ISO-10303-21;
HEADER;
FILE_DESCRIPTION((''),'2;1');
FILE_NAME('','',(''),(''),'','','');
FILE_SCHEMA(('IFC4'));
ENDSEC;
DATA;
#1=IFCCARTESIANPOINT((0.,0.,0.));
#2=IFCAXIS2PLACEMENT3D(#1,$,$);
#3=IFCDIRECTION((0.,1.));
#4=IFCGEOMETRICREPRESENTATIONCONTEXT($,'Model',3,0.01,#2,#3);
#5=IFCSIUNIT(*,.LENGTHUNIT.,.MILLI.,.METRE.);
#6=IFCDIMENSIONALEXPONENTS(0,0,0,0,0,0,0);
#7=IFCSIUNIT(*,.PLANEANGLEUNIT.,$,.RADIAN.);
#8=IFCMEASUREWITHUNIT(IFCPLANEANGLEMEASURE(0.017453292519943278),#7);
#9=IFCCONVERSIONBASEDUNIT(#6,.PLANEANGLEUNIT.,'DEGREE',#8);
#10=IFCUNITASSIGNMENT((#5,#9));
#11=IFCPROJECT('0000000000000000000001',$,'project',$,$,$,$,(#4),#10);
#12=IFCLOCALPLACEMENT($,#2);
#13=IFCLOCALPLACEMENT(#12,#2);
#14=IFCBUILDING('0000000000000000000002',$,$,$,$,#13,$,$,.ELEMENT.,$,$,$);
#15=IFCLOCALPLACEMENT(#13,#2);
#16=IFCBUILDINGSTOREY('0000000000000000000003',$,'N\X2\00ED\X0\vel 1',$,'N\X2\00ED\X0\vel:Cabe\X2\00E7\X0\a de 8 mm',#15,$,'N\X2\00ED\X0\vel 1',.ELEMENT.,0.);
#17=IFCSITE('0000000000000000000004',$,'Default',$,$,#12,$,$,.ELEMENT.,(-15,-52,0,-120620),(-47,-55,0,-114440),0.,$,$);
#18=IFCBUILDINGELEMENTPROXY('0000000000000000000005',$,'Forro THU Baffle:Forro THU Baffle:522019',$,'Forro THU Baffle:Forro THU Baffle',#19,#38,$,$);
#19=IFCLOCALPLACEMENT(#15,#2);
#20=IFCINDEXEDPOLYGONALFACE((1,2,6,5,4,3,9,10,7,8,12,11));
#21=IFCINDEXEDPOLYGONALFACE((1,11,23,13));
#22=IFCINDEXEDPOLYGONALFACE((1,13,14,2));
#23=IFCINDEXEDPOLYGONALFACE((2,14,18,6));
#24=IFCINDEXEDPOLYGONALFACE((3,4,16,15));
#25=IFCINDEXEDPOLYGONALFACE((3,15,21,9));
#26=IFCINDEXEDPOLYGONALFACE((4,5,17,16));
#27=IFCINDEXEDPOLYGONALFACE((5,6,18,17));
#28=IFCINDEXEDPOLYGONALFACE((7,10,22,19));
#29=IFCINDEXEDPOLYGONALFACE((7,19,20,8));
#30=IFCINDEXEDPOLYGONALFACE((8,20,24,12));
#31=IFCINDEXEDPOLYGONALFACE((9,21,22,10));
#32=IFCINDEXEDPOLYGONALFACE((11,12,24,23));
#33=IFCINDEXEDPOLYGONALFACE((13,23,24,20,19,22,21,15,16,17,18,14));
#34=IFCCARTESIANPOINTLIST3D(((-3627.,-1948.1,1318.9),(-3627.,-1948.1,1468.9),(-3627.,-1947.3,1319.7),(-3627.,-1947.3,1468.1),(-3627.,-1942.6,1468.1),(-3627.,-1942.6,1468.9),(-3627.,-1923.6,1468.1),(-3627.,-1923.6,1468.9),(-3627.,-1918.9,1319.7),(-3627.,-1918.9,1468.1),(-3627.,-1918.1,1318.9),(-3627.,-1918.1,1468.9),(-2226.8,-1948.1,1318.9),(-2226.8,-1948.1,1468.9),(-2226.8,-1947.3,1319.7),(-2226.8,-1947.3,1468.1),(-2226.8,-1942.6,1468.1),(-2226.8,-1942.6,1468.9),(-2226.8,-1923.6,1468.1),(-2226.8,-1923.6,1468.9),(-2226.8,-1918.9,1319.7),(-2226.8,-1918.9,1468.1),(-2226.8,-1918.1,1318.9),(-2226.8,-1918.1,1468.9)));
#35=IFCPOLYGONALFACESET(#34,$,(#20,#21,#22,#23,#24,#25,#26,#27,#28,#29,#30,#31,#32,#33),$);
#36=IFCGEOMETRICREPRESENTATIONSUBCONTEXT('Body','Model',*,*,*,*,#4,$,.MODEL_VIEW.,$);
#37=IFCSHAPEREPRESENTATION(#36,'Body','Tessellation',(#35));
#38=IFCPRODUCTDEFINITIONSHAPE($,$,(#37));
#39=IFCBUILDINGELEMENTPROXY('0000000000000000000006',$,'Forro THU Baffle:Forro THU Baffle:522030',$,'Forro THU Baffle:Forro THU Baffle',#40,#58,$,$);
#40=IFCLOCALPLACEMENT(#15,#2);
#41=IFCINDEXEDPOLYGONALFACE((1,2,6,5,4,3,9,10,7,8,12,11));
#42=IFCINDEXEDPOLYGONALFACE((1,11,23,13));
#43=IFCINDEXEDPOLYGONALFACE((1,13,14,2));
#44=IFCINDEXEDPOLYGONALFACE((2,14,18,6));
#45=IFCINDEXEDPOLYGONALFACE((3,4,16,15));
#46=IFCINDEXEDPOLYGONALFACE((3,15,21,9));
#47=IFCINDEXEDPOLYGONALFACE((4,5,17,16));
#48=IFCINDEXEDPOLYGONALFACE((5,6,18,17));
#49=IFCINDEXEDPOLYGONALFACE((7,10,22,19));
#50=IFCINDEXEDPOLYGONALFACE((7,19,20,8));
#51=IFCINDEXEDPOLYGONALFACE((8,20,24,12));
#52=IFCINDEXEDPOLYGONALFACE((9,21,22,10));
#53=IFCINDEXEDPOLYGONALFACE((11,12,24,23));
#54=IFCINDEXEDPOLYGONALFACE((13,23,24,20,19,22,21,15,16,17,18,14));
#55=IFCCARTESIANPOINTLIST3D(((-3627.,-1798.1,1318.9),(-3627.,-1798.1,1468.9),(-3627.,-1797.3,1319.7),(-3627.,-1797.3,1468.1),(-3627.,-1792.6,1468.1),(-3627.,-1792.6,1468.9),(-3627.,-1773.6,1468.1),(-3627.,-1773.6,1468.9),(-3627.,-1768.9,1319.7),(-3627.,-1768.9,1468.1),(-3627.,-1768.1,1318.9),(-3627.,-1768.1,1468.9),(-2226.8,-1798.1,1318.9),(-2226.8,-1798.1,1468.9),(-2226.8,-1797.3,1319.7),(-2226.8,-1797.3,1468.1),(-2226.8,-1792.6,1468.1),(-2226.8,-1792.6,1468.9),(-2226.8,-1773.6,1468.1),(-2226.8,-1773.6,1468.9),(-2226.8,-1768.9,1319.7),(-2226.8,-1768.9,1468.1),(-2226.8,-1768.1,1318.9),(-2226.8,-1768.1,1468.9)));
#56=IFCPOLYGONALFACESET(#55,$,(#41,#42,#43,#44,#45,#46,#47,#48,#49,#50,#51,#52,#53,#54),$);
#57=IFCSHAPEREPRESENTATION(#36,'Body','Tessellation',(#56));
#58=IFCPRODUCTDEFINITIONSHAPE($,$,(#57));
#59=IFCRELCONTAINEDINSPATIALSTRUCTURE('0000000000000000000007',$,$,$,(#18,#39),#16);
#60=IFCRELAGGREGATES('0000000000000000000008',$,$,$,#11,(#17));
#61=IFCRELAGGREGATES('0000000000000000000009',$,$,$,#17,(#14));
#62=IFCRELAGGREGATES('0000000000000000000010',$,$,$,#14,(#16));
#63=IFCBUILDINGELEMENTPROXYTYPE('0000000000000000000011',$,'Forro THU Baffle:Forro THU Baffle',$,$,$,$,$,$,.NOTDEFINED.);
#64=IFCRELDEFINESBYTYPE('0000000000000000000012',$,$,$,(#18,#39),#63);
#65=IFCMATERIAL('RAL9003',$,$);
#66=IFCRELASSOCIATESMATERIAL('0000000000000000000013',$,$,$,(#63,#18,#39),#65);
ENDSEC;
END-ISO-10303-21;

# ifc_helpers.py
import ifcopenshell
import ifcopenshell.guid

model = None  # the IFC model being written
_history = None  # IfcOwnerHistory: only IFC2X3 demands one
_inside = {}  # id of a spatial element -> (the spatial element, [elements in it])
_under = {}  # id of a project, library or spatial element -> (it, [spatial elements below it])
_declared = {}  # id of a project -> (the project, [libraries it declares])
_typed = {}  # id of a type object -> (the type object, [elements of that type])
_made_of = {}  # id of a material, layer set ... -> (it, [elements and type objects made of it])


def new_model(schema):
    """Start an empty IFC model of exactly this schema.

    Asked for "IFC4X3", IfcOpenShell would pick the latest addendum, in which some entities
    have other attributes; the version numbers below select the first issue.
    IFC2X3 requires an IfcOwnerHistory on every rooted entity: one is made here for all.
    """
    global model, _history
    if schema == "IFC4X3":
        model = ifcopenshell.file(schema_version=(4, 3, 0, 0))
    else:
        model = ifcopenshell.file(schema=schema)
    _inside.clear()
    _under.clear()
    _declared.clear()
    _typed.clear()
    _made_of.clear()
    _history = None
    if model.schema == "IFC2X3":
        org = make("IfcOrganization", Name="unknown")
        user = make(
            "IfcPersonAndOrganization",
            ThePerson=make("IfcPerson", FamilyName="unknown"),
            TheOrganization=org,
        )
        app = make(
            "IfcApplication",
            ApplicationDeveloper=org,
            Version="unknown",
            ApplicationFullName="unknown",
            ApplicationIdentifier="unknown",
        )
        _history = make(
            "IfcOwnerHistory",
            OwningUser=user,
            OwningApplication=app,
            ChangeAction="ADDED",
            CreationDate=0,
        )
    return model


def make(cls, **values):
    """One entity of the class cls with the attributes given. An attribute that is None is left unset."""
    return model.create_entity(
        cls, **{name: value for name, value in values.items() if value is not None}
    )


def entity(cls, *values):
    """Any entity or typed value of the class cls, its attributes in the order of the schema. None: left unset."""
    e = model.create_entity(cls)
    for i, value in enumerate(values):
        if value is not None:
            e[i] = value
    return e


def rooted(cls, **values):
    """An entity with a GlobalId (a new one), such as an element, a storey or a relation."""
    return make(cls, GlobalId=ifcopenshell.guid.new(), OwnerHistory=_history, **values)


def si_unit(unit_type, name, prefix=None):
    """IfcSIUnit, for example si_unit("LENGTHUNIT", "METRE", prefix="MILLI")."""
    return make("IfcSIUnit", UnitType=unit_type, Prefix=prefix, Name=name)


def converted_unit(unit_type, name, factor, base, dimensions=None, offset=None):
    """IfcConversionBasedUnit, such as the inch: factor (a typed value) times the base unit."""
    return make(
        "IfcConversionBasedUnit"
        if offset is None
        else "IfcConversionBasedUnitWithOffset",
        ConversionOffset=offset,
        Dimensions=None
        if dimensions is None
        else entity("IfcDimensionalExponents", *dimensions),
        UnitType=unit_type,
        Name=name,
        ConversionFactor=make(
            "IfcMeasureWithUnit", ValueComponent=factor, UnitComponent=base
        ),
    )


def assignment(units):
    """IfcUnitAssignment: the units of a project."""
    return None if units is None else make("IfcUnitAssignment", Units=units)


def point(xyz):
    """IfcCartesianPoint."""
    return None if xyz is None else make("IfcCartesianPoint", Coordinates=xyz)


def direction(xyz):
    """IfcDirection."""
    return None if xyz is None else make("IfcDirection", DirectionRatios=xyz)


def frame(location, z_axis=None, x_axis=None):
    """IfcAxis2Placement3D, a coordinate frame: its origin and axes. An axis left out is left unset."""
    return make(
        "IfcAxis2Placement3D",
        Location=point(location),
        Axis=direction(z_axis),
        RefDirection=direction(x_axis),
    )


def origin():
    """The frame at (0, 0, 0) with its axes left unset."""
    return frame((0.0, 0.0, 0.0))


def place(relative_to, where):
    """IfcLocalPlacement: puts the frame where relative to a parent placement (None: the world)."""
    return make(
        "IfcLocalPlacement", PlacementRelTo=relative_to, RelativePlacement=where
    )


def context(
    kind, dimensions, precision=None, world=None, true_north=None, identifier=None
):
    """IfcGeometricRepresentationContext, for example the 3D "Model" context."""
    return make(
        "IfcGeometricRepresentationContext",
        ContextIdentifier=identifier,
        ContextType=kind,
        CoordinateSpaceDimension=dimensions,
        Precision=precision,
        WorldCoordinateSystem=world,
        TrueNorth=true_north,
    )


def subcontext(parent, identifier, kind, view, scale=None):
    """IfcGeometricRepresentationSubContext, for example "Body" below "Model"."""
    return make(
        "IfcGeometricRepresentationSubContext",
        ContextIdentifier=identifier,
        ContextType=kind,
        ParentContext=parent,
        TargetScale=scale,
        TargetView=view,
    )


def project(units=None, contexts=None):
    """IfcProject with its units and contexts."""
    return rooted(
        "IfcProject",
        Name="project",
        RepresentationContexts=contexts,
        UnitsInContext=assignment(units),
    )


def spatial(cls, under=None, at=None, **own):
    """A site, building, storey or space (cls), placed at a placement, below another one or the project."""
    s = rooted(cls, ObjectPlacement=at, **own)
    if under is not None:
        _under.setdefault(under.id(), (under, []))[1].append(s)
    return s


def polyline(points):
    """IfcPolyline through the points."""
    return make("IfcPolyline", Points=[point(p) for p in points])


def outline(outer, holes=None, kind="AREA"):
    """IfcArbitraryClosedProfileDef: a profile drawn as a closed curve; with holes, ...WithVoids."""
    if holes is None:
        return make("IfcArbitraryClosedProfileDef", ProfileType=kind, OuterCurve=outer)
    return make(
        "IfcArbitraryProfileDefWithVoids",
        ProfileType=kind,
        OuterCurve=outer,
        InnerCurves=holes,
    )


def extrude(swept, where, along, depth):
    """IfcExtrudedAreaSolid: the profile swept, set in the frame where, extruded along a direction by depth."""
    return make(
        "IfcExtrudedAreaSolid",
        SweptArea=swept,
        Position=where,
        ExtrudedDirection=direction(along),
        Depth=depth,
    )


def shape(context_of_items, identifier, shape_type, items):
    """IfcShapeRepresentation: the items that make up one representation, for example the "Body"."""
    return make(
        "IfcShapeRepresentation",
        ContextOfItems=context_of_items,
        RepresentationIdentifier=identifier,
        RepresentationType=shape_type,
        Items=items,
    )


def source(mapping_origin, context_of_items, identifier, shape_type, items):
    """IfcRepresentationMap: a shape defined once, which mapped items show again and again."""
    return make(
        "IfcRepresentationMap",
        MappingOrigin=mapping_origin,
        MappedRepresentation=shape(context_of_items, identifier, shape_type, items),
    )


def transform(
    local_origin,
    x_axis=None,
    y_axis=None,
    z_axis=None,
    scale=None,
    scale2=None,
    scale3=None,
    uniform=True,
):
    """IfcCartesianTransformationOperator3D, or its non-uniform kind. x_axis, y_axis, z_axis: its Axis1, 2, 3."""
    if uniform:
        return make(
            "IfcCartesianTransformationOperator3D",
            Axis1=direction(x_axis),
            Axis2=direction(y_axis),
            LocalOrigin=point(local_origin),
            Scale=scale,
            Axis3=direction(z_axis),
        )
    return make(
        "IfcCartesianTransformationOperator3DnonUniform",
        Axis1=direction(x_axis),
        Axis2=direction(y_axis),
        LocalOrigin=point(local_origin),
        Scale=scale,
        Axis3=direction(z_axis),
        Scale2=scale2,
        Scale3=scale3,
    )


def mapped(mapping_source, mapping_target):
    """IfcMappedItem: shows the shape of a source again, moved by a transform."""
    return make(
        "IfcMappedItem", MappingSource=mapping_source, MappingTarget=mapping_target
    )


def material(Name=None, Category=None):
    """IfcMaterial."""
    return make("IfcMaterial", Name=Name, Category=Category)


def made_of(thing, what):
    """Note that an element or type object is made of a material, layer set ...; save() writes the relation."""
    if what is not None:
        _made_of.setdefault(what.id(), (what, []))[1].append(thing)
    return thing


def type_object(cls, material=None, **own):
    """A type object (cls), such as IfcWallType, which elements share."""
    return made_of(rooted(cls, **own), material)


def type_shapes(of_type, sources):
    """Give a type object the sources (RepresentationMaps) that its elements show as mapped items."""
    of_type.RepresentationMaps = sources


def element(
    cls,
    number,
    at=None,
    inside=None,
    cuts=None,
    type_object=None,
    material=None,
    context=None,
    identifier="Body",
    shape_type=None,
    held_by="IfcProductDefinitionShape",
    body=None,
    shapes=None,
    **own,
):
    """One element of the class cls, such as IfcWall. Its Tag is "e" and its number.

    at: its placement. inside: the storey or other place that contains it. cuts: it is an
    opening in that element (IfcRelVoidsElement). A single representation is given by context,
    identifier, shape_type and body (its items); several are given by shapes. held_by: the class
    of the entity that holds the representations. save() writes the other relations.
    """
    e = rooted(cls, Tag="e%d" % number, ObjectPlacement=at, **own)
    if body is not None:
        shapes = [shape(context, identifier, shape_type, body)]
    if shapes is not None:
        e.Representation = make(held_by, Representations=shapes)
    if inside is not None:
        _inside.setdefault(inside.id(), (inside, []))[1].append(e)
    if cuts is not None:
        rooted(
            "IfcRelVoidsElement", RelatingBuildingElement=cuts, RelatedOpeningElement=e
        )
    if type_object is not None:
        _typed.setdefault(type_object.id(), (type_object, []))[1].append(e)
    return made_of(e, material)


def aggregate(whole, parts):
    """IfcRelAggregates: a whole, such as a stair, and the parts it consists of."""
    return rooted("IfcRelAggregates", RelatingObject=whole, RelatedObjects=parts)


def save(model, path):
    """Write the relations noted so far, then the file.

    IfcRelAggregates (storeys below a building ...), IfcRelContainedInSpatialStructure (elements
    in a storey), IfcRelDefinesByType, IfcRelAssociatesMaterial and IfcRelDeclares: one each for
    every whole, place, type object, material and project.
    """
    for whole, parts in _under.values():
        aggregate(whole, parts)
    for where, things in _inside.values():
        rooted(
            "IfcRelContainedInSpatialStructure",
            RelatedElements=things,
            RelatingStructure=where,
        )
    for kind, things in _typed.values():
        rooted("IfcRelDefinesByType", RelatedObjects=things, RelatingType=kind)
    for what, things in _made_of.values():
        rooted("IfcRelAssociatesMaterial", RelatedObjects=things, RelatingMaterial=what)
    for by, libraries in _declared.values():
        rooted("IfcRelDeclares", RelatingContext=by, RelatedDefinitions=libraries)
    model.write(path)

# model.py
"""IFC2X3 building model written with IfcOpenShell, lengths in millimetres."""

from ifc_helpers import new_model, entity, si_unit, converted_unit, direction, frame, origin, place, context, subcontext, project, spatial, polyline, outline, extrude, source, transform, mapped, material, type_object, type_shapes, element, save


model = new_model("IFC2X3")

# Units and contexts
model_context = context("Model", 3, precision=0.01, world=origin(), true_north=direction((0.0, 1.0)))
body_context = subcontext(model_context, "Body", "Model", "MODEL_VIEW")
ifc_project = project(units=[si_unit("LENGTHUNIT", "METRE", prefix="MILLI"), converted_unit("PLANEANGLEUNIT", "DEGREE", entity("IfcPlaneAngleMeasure", 0.017453292519943278), si_unit("PLANEANGLEUNIT", "RADIAN"), dimensions=[0, 0, 0, 0, 0, 0, 0])], contexts=[model_context])

# Site, building, storey
site_placement = place(None, origin())
site = spatial("IfcSite", under=ifc_project, at=site_placement, Name="Default", CompositionType="ELEMENT", RefLatitude=(-15, -52, 0, -120620), RefLongitude=(-47, -55, 0, -114440), RefElevation=0.0)
building_placement = place(site_placement, origin())
building = spatial("IfcBuilding", under=site, at=building_placement, CompositionType="ELEMENT")
storey_placement = place(building_placement, origin())
storey = spatial("IfcBuildingStorey", under=building, at=storey_placement, Name="Nível 1", ObjectType="Nível:Cabeça de 8 mm", LongName="Nível 1", CompositionType="ELEMENT", Elevation=0.0)

# Building element proxies
ifc_material = material(Name="RAL9003")
building_element_proxy_type_1 = type_object("IfcBuildingElementProxyType", Name="Forro THU Baffle:Forro THU Baffle", PredefinedType="NOTDEFINED", material=ifc_material)
shared_shape_1 = source(origin(), body_context, "Body", "SweptSolid", [
    extrude(outline(polyline([(-15.0, -99.9), (15.0, -99.9), (15.0, 50.1), (9.5, 50.1), (9.5, 49.3), (14.2, 49.3), (14.2, -99.1), (-14.2, -99.1), (-14.2, 49.3), (-9.5, 49.3), (-9.5, 50.1), (-15.0, 50.1), (-15.0, -99.9)])), frame((0.0, 15.0, -50.1), z_axis=(1.0, 0.0, 0.0), x_axis=(0.0, 1.0, 0.0)), (0.0, 0.0, 1.0), 1400.1),
])
type_shapes(building_element_proxy_type_1, [shared_shape_1])
for number, where, name in (
    (1, (-3627.0, -1948.1, 1468.9), "Forro THU Baffle:Forro THU Baffle:522019"),
    (2, (-3627.0, -1798.1, 1468.9), "Forro THU Baffle:Forro THU Baffle:522030"),
):
    element("IfcBuildingElementProxy", number, at=place(storey_placement, frame(where)), inside=storey, type_object=building_element_proxy_type_1, material=ifc_material, Name=name, ObjectType="Forro THU Baffle:Forro THU Baffle", context=body_context, shape_type="MappedRepresentation", body=[
        mapped(shared_shape_1, transform((0.0, 0.0, 0.0), scale=1.0)),
    ])

save(model, "model.ifc")
